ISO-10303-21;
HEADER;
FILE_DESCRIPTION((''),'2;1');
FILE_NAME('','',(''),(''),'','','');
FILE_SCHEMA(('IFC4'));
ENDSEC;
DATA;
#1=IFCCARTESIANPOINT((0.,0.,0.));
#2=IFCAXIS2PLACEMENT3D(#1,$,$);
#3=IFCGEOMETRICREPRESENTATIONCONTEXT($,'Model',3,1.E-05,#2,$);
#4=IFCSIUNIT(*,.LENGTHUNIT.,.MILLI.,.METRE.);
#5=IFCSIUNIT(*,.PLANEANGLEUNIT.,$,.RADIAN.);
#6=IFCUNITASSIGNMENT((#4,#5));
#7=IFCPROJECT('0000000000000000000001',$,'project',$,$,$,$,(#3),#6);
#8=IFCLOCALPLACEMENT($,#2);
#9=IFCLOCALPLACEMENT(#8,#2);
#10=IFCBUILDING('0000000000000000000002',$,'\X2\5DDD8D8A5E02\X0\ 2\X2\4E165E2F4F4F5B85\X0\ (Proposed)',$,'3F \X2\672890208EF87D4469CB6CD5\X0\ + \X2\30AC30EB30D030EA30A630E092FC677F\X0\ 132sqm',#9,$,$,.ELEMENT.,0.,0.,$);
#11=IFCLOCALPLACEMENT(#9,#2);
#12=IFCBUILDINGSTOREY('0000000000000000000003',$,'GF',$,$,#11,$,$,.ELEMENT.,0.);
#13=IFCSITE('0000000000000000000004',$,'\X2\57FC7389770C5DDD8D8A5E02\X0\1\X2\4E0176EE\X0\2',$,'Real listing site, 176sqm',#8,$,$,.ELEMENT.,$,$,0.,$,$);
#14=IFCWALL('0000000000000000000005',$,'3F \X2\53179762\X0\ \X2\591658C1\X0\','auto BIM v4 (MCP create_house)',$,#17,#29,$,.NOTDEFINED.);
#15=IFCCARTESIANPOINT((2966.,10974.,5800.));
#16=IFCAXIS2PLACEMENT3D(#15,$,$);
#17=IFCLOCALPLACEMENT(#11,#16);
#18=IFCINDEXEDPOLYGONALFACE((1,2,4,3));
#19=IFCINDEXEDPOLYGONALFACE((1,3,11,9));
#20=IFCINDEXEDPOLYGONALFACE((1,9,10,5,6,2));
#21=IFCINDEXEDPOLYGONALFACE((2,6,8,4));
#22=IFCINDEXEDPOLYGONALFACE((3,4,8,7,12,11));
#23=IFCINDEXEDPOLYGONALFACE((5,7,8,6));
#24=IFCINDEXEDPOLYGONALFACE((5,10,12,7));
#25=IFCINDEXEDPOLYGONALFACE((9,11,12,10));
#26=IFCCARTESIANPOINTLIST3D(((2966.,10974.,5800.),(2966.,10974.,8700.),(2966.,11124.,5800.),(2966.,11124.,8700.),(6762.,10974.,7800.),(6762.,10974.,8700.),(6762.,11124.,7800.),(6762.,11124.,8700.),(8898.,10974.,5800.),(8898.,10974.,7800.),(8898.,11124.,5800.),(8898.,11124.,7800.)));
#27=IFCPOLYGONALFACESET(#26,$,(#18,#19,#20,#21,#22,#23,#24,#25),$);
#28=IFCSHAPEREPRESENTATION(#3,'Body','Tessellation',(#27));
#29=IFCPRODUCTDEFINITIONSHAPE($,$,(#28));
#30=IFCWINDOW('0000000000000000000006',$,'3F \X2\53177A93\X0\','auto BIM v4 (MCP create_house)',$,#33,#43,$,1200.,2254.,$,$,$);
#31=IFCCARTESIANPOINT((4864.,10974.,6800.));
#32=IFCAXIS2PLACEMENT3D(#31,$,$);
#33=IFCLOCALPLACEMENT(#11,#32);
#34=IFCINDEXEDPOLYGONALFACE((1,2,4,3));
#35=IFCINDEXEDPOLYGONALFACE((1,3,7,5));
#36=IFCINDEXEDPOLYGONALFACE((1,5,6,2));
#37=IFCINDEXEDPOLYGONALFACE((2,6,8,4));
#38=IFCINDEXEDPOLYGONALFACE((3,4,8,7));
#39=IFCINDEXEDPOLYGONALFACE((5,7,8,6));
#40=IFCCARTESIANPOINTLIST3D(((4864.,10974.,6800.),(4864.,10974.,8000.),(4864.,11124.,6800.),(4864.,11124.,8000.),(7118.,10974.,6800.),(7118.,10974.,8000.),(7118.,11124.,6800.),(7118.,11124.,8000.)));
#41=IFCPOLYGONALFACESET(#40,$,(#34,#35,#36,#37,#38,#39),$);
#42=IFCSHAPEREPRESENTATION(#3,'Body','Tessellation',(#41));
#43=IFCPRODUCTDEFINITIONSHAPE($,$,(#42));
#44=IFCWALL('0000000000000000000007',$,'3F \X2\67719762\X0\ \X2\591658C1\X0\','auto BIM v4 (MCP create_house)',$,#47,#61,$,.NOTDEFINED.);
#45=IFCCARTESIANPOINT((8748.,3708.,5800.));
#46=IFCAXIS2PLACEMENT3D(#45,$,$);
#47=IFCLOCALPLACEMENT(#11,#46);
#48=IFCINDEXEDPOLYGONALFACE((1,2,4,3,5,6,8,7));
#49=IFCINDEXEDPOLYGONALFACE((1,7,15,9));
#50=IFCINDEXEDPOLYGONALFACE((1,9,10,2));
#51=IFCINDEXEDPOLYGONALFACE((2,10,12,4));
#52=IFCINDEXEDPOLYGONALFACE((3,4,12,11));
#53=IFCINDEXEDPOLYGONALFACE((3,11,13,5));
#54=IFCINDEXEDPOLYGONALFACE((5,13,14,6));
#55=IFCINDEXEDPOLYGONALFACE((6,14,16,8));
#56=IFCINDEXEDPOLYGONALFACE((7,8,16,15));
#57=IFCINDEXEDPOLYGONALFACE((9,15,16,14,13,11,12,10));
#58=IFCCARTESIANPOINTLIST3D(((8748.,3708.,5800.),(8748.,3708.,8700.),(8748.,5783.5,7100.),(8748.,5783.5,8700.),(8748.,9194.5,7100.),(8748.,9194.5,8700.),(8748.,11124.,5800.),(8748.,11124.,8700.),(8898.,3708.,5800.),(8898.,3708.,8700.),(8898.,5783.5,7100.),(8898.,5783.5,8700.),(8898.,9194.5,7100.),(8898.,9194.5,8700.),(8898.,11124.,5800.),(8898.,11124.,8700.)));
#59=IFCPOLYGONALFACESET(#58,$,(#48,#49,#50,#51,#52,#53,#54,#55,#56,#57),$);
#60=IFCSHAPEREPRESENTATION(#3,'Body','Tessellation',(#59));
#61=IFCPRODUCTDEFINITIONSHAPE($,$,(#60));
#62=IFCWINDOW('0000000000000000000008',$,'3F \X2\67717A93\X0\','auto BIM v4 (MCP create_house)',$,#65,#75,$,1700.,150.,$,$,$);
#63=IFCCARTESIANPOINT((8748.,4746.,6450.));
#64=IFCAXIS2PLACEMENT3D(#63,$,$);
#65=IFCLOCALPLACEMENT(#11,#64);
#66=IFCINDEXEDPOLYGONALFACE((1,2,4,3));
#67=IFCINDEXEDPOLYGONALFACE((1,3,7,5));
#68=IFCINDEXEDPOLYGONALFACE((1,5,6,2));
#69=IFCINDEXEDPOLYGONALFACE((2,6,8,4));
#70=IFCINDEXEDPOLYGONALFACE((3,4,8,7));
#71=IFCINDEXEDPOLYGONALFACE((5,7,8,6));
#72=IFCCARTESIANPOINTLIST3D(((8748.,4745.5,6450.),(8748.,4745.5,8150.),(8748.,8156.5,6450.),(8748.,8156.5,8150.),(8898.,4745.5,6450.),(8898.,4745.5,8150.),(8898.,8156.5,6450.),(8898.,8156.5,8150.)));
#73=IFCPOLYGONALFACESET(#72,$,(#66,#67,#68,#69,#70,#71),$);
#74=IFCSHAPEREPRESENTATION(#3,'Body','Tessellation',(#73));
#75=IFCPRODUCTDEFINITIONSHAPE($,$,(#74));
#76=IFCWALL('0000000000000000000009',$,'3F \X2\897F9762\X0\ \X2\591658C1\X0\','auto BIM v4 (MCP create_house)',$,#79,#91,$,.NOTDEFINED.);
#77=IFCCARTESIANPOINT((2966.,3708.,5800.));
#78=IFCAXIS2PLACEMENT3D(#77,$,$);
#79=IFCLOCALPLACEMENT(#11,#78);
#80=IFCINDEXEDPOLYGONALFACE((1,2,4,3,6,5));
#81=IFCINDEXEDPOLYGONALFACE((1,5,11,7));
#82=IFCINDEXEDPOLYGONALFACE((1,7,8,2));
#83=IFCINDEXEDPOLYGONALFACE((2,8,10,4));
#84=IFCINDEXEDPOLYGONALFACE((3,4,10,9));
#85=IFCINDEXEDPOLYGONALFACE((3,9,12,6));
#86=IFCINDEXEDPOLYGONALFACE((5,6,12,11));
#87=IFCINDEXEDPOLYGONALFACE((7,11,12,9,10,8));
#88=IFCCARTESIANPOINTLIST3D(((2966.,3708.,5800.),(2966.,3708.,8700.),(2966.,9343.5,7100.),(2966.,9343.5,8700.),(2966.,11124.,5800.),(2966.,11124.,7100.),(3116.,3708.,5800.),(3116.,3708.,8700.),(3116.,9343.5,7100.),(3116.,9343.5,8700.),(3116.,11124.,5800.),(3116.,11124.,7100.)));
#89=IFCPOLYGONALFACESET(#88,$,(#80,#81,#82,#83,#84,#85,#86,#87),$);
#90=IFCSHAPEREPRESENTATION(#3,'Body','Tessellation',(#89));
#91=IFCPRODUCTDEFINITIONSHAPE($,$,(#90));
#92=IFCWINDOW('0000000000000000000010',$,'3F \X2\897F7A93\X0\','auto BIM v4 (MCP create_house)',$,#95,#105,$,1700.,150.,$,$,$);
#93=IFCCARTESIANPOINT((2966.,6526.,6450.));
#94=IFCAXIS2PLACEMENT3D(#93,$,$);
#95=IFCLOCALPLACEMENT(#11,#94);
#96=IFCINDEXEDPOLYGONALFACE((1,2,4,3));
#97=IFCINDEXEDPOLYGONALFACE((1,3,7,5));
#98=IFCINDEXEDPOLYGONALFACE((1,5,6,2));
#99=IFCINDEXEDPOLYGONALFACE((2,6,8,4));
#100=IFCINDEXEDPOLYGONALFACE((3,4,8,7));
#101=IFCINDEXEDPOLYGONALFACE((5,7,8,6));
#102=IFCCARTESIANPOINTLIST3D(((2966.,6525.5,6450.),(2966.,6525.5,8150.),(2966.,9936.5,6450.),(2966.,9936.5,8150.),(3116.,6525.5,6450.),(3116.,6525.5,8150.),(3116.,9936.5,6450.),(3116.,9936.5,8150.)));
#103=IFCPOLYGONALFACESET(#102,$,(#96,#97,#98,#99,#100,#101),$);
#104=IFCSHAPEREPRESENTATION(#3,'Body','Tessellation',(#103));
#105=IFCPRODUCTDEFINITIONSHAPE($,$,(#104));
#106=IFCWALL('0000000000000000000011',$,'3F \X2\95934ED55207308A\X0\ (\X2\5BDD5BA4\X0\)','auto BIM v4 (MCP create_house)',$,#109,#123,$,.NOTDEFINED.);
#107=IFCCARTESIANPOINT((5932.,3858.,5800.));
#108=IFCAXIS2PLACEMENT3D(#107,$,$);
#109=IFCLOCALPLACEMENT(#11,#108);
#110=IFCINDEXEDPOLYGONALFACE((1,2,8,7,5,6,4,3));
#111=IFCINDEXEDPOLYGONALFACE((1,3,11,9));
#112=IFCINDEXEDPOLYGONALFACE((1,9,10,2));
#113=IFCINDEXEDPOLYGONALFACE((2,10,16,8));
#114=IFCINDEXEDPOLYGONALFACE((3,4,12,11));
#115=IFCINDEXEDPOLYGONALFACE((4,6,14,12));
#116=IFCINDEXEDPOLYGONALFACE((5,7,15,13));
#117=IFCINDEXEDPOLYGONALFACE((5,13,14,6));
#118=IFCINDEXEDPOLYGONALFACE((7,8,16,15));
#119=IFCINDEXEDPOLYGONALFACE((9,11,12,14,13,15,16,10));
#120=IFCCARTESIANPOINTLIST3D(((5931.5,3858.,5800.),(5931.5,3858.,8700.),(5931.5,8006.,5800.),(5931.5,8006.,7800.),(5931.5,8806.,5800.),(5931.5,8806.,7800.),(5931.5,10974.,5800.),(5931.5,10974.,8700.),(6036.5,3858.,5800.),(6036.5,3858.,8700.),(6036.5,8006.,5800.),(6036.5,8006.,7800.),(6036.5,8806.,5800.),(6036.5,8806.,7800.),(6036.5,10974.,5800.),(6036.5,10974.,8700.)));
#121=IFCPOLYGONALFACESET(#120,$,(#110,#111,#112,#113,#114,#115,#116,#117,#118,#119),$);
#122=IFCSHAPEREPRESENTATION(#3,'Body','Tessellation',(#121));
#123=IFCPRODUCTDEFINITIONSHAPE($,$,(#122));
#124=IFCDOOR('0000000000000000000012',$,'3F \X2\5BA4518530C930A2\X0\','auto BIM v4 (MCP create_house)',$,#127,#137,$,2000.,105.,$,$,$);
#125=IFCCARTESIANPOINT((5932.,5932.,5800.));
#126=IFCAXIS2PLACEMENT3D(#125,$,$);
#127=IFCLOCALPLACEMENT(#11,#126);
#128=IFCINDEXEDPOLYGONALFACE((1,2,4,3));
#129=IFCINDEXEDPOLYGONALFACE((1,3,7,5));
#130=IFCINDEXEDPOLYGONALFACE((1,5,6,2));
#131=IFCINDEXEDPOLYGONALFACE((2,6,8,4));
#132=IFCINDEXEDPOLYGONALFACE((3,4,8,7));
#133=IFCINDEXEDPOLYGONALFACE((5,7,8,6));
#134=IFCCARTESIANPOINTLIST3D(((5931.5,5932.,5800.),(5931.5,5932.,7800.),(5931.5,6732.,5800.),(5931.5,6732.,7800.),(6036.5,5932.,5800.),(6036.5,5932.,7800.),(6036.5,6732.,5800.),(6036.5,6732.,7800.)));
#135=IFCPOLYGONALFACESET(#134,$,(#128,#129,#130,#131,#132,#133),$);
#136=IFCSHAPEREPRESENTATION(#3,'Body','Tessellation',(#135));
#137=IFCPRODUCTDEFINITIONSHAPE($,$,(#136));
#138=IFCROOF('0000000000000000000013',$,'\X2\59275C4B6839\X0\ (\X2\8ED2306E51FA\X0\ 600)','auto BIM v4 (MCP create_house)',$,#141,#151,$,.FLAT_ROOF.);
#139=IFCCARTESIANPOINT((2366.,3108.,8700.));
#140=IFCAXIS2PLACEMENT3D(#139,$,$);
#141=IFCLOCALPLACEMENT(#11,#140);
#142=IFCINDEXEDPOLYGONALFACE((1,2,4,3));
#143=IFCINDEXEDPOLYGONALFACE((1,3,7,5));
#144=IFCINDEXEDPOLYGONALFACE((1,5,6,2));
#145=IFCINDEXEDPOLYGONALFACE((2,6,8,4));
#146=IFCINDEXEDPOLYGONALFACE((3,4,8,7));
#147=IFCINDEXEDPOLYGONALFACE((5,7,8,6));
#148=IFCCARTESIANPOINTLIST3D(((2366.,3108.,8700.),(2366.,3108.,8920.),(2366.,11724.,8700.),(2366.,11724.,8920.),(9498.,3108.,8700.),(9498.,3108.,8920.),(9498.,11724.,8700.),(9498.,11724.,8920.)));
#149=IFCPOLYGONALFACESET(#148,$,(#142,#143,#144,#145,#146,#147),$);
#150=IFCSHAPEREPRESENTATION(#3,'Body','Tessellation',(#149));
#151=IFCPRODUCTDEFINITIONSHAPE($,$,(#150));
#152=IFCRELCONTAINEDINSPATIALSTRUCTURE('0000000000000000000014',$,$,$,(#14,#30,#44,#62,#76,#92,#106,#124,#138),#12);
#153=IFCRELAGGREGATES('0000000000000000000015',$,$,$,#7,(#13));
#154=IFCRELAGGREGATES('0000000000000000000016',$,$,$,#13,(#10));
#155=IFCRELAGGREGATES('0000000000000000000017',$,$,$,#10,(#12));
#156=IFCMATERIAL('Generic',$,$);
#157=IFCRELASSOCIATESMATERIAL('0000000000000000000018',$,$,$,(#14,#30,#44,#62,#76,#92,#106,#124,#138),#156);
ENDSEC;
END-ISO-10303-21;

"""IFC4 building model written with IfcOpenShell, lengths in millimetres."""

from ifc_helpers import new_model, si_unit, frame, frame_2d, origin, place, context, project, spatial, rectangle, extrude, material, element, fill, save


model = new_model("IFC4")

# Units and contexts
model_context = context("Model", 3, precision=1e-05, world=origin())
ifc_project = project(units=[si_unit("LENGTHUNIT", "METRE", prefix="MILLI"), si_unit("PLANEANGLEUNIT", "RADIAN")], contexts=[model_context])

# Site, building, storey
site_placement = place(None, origin())
site = spatial("IfcSite", under=ifc_project, at=site_placement, Name="埼玉県川越市1丁目2", ObjectType="Real listing site, 176sqm", CompositionType="ELEMENT", RefElevation=0.0)
building_placement = place(site_placement, origin())
building = spatial("IfcBuilding", under=site, at=building_placement, Name="川越市 2世帯住宅 (Proposed)", ObjectType="3F 木造軸組構法 + ガルバリウム鋼板 132sqm", CompositionType="ELEMENT", ElevationOfRefHeight=0.0, ElevationOfTerrain=0.0)
storey_placement = place(building_placement, origin())
storey = spatial("IfcBuildingStorey", under=building, at=storey_placement, Name="GF", CompositionType="ELEMENT", Elevation=0.0)

# Shared definitions
ifc_material = material(Name="Generic")

# Walls, openings, windows
wall_1_placement = place(storey_placement, frame((2966.0, 10974.0, 5800.0)))
wall_1 = element("IfcWall", 1, at=wall_1_placement, inside=storey, material=ifc_material, Name="3F 北面 外壁", Description="auto BIM v4 (MCP create_house)", PredefinedType="NOTDEFINED", context=model_context, shape_type="SweptSolid", body=[
    extrude(rectangle(XDim=5932.0, YDim=150.0, at=frame_2d((2966.0, 75.0))), frame((2966.0, 10974.0, 5800.0)), (0.0, 0.0, 1.0), 2900.0),
])
opening_1_placement = place(storey_placement, frame((4864.0, 10974.0, 6800.0)))
opening_1 = element("IfcOpeningElement", 2, at=opening_1_placement, cuts=wall_1, PredefinedType="NOTDEFINED", context=model_context, shape_type="SweptSolid", body=[
    extrude(rectangle(XDim=2254.0, YDim=150.0, at=frame_2d((1127.0, 75.0))), frame((4864.0, 10974.0, 6800.0)), (0.0, 0.0, 1.0), 1200.0),
])
window_1_placement = place(storey_placement, frame((4864.0, 10974.0, 6800.0)))
window_1 = element("IfcWindow", 3, at=window_1_placement, inside=storey, material=ifc_material, Name="3F 北窓", Description="auto BIM v4 (MCP create_house)", OverallHeight=1200.0, OverallWidth=2254.0, context=model_context, shape_type="SweptSolid", body=[
    extrude(rectangle(XDim=2254.0, YDim=150.0, at=frame_2d((1127.0, 75.0))), frame((4864.0, 10974.0, 6800.0)), (0.0, 0.0, 1.0), 1200.0),
])
fill(opening_1, window_1)
wall_2_placement = place(storey_placement, frame((8748.0, 3708.0, 5800.0)))
wall_2 = element("IfcWall", 4, at=wall_2_placement, inside=storey, material=ifc_material, Name="3F 東面 外壁", Description="auto BIM v4 (MCP create_house)", PredefinedType="NOTDEFINED", context=model_context, shape_type="SweptSolid", body=[
    extrude(rectangle(XDim=150.0, YDim=7416.0, at=frame_2d((75.0, 3708.0))), frame((8748.0, 3708.0, 5800.0)), (0.0, 0.0, 1.0), 2900.0),
])
opening_2_placement = place(storey_placement, frame((8748.0, 4746.0, 6450.0)))
opening_2 = element("IfcOpeningElement", 5, at=opening_2_placement, cuts=wall_2, PredefinedType="NOTDEFINED", context=model_context, shape_type="SweptSolid", body=[
    extrude(rectangle(XDim=150.0, YDim=3411.0, at=frame_2d((75.0, 1705.0))), frame((8748.0, 4746.0, 6450.0)), (0.0, 0.0, 1.0), 1700.0),
])
window_2_placement = place(storey_placement, frame((8748.0, 4746.0, 6450.0)))
window_2 = element("IfcWindow", 6, at=window_2_placement, inside=storey, material=ifc_material, Name="3F 東窓", Description="auto BIM v4 (MCP create_house)", OverallHeight=1700.0, OverallWidth=150.0, context=model_context, shape_type="SweptSolid", body=[
    extrude(rectangle(XDim=150.0, YDim=3411.0, at=frame_2d((75.0, 1705.0))), frame((8748.0, 4746.0, 6450.0)), (0.0, 0.0, 1.0), 1700.0),
])
fill(opening_2, window_2)
wall_3_placement = place(storey_placement, frame((2966.0, 3708.0, 5800.0)))
wall_3 = element("IfcWall", 7, at=wall_3_placement, inside=storey, material=ifc_material, Name="3F 西面 外壁", Description="auto BIM v4 (MCP create_house)", PredefinedType="NOTDEFINED", context=model_context, shape_type="SweptSolid", body=[
    extrude(rectangle(XDim=150.0, YDim=7416.0, at=frame_2d((75.0, 3708.0))), frame((2966.0, 3708.0, 5800.0)), (0.0, 0.0, 1.0), 2900.0),
])
opening_3_placement = place(storey_placement, frame((2966.0, 6526.0, 6450.0)))
opening_3 = element("IfcOpeningElement", 8, at=opening_3_placement, cuts=wall_3, PredefinedType="NOTDEFINED", context=model_context, shape_type="SweptSolid", body=[
    extrude(rectangle(XDim=150.0, YDim=3411.0, at=frame_2d((75.0, 1705.0))), frame((2966.0, 6526.0, 6450.0)), (0.0, 0.0, 1.0), 1700.0),
])
window_3_placement = place(storey_placement, frame((2966.0, 6526.0, 6450.0)))
window_3 = element("IfcWindow", 9, at=window_3_placement, inside=storey, material=ifc_material, Name="3F 西窓", Description="auto BIM v4 (MCP create_house)", OverallHeight=1700.0, OverallWidth=150.0, context=model_context, shape_type="SweptSolid", body=[
    extrude(rectangle(XDim=150.0, YDim=3411.0, at=frame_2d((75.0, 1705.0))), frame((2966.0, 6526.0, 6450.0)), (0.0, 0.0, 1.0), 1700.0),
])
fill(opening_3, window_3)

# Wall, opening, door
wall_4_placement = place(storey_placement, frame((5932.0, 3858.0, 5800.0)))
wall_4 = element("IfcWall", 10, at=wall_4_placement, inside=storey, material=ifc_material, Name="3F 間仕切り (寝室)", Description="auto BIM v4 (MCP create_house)", PredefinedType="NOTDEFINED", context=model_context, shape_type="SweptSolid", body=[
    extrude(rectangle(XDim=105.0, YDim=7116.0, at=frame_2d((52.0, 3558.0))), frame((5932.0, 3858.0, 5800.0)), (0.0, 0.0, 1.0), 2900.0),
])
opening_4_placement = place(storey_placement, frame((5932.0, 5932.0, 5800.0)))
opening_4 = element("IfcOpeningElement", 11, at=opening_4_placement, cuts=wall_4, PredefinedType="NOTDEFINED", context=model_context, shape_type="SweptSolid", body=[
    extrude(rectangle(XDim=105.0, YDim=800.0, at=frame_2d((52.0, 400.0))), frame((5932.0, 5932.0, 5800.0)), (0.0, 0.0, 1.0), 2000.0),
])
door_1_placement = place(storey_placement, frame((5932.0, 5932.0, 5800.0)))
door_1 = element("IfcDoor", 12, at=door_1_placement, inside=storey, material=ifc_material, Name="3F 室内ドア", Description="auto BIM v4 (MCP create_house)", OverallHeight=2000.0, OverallWidth=105.0, context=model_context, shape_type="SweptSolid", body=[
    extrude(rectangle(XDim=105.0, YDim=800.0, at=frame_2d((52.0, 400.0))), frame((5932.0, 5932.0, 5800.0)), (0.0, 0.0, 1.0), 2000.0),
])
fill(opening_4, door_1)

# Roof
roof_placement = place(storey_placement, frame((2366.0, 3108.0, 8700.0)))
element("IfcRoof", 13, at=roof_placement, inside=storey, material=ifc_material, Name="大屋根 (軒の出 600)", Description="auto BIM v4 (MCP create_house)", PredefinedType="FLAT_ROOF", context=model_context, shape_type="SweptSolid", body=[
    extrude(rectangle(XDim=7132.0, YDim=8616.0, at=frame_2d((3566.0, 4308.0))), frame((2366.0, 3108.0, 8700.0)), (0.0, 0.0, 1.0), 220.0),
])

save(model, "model.ifc")
